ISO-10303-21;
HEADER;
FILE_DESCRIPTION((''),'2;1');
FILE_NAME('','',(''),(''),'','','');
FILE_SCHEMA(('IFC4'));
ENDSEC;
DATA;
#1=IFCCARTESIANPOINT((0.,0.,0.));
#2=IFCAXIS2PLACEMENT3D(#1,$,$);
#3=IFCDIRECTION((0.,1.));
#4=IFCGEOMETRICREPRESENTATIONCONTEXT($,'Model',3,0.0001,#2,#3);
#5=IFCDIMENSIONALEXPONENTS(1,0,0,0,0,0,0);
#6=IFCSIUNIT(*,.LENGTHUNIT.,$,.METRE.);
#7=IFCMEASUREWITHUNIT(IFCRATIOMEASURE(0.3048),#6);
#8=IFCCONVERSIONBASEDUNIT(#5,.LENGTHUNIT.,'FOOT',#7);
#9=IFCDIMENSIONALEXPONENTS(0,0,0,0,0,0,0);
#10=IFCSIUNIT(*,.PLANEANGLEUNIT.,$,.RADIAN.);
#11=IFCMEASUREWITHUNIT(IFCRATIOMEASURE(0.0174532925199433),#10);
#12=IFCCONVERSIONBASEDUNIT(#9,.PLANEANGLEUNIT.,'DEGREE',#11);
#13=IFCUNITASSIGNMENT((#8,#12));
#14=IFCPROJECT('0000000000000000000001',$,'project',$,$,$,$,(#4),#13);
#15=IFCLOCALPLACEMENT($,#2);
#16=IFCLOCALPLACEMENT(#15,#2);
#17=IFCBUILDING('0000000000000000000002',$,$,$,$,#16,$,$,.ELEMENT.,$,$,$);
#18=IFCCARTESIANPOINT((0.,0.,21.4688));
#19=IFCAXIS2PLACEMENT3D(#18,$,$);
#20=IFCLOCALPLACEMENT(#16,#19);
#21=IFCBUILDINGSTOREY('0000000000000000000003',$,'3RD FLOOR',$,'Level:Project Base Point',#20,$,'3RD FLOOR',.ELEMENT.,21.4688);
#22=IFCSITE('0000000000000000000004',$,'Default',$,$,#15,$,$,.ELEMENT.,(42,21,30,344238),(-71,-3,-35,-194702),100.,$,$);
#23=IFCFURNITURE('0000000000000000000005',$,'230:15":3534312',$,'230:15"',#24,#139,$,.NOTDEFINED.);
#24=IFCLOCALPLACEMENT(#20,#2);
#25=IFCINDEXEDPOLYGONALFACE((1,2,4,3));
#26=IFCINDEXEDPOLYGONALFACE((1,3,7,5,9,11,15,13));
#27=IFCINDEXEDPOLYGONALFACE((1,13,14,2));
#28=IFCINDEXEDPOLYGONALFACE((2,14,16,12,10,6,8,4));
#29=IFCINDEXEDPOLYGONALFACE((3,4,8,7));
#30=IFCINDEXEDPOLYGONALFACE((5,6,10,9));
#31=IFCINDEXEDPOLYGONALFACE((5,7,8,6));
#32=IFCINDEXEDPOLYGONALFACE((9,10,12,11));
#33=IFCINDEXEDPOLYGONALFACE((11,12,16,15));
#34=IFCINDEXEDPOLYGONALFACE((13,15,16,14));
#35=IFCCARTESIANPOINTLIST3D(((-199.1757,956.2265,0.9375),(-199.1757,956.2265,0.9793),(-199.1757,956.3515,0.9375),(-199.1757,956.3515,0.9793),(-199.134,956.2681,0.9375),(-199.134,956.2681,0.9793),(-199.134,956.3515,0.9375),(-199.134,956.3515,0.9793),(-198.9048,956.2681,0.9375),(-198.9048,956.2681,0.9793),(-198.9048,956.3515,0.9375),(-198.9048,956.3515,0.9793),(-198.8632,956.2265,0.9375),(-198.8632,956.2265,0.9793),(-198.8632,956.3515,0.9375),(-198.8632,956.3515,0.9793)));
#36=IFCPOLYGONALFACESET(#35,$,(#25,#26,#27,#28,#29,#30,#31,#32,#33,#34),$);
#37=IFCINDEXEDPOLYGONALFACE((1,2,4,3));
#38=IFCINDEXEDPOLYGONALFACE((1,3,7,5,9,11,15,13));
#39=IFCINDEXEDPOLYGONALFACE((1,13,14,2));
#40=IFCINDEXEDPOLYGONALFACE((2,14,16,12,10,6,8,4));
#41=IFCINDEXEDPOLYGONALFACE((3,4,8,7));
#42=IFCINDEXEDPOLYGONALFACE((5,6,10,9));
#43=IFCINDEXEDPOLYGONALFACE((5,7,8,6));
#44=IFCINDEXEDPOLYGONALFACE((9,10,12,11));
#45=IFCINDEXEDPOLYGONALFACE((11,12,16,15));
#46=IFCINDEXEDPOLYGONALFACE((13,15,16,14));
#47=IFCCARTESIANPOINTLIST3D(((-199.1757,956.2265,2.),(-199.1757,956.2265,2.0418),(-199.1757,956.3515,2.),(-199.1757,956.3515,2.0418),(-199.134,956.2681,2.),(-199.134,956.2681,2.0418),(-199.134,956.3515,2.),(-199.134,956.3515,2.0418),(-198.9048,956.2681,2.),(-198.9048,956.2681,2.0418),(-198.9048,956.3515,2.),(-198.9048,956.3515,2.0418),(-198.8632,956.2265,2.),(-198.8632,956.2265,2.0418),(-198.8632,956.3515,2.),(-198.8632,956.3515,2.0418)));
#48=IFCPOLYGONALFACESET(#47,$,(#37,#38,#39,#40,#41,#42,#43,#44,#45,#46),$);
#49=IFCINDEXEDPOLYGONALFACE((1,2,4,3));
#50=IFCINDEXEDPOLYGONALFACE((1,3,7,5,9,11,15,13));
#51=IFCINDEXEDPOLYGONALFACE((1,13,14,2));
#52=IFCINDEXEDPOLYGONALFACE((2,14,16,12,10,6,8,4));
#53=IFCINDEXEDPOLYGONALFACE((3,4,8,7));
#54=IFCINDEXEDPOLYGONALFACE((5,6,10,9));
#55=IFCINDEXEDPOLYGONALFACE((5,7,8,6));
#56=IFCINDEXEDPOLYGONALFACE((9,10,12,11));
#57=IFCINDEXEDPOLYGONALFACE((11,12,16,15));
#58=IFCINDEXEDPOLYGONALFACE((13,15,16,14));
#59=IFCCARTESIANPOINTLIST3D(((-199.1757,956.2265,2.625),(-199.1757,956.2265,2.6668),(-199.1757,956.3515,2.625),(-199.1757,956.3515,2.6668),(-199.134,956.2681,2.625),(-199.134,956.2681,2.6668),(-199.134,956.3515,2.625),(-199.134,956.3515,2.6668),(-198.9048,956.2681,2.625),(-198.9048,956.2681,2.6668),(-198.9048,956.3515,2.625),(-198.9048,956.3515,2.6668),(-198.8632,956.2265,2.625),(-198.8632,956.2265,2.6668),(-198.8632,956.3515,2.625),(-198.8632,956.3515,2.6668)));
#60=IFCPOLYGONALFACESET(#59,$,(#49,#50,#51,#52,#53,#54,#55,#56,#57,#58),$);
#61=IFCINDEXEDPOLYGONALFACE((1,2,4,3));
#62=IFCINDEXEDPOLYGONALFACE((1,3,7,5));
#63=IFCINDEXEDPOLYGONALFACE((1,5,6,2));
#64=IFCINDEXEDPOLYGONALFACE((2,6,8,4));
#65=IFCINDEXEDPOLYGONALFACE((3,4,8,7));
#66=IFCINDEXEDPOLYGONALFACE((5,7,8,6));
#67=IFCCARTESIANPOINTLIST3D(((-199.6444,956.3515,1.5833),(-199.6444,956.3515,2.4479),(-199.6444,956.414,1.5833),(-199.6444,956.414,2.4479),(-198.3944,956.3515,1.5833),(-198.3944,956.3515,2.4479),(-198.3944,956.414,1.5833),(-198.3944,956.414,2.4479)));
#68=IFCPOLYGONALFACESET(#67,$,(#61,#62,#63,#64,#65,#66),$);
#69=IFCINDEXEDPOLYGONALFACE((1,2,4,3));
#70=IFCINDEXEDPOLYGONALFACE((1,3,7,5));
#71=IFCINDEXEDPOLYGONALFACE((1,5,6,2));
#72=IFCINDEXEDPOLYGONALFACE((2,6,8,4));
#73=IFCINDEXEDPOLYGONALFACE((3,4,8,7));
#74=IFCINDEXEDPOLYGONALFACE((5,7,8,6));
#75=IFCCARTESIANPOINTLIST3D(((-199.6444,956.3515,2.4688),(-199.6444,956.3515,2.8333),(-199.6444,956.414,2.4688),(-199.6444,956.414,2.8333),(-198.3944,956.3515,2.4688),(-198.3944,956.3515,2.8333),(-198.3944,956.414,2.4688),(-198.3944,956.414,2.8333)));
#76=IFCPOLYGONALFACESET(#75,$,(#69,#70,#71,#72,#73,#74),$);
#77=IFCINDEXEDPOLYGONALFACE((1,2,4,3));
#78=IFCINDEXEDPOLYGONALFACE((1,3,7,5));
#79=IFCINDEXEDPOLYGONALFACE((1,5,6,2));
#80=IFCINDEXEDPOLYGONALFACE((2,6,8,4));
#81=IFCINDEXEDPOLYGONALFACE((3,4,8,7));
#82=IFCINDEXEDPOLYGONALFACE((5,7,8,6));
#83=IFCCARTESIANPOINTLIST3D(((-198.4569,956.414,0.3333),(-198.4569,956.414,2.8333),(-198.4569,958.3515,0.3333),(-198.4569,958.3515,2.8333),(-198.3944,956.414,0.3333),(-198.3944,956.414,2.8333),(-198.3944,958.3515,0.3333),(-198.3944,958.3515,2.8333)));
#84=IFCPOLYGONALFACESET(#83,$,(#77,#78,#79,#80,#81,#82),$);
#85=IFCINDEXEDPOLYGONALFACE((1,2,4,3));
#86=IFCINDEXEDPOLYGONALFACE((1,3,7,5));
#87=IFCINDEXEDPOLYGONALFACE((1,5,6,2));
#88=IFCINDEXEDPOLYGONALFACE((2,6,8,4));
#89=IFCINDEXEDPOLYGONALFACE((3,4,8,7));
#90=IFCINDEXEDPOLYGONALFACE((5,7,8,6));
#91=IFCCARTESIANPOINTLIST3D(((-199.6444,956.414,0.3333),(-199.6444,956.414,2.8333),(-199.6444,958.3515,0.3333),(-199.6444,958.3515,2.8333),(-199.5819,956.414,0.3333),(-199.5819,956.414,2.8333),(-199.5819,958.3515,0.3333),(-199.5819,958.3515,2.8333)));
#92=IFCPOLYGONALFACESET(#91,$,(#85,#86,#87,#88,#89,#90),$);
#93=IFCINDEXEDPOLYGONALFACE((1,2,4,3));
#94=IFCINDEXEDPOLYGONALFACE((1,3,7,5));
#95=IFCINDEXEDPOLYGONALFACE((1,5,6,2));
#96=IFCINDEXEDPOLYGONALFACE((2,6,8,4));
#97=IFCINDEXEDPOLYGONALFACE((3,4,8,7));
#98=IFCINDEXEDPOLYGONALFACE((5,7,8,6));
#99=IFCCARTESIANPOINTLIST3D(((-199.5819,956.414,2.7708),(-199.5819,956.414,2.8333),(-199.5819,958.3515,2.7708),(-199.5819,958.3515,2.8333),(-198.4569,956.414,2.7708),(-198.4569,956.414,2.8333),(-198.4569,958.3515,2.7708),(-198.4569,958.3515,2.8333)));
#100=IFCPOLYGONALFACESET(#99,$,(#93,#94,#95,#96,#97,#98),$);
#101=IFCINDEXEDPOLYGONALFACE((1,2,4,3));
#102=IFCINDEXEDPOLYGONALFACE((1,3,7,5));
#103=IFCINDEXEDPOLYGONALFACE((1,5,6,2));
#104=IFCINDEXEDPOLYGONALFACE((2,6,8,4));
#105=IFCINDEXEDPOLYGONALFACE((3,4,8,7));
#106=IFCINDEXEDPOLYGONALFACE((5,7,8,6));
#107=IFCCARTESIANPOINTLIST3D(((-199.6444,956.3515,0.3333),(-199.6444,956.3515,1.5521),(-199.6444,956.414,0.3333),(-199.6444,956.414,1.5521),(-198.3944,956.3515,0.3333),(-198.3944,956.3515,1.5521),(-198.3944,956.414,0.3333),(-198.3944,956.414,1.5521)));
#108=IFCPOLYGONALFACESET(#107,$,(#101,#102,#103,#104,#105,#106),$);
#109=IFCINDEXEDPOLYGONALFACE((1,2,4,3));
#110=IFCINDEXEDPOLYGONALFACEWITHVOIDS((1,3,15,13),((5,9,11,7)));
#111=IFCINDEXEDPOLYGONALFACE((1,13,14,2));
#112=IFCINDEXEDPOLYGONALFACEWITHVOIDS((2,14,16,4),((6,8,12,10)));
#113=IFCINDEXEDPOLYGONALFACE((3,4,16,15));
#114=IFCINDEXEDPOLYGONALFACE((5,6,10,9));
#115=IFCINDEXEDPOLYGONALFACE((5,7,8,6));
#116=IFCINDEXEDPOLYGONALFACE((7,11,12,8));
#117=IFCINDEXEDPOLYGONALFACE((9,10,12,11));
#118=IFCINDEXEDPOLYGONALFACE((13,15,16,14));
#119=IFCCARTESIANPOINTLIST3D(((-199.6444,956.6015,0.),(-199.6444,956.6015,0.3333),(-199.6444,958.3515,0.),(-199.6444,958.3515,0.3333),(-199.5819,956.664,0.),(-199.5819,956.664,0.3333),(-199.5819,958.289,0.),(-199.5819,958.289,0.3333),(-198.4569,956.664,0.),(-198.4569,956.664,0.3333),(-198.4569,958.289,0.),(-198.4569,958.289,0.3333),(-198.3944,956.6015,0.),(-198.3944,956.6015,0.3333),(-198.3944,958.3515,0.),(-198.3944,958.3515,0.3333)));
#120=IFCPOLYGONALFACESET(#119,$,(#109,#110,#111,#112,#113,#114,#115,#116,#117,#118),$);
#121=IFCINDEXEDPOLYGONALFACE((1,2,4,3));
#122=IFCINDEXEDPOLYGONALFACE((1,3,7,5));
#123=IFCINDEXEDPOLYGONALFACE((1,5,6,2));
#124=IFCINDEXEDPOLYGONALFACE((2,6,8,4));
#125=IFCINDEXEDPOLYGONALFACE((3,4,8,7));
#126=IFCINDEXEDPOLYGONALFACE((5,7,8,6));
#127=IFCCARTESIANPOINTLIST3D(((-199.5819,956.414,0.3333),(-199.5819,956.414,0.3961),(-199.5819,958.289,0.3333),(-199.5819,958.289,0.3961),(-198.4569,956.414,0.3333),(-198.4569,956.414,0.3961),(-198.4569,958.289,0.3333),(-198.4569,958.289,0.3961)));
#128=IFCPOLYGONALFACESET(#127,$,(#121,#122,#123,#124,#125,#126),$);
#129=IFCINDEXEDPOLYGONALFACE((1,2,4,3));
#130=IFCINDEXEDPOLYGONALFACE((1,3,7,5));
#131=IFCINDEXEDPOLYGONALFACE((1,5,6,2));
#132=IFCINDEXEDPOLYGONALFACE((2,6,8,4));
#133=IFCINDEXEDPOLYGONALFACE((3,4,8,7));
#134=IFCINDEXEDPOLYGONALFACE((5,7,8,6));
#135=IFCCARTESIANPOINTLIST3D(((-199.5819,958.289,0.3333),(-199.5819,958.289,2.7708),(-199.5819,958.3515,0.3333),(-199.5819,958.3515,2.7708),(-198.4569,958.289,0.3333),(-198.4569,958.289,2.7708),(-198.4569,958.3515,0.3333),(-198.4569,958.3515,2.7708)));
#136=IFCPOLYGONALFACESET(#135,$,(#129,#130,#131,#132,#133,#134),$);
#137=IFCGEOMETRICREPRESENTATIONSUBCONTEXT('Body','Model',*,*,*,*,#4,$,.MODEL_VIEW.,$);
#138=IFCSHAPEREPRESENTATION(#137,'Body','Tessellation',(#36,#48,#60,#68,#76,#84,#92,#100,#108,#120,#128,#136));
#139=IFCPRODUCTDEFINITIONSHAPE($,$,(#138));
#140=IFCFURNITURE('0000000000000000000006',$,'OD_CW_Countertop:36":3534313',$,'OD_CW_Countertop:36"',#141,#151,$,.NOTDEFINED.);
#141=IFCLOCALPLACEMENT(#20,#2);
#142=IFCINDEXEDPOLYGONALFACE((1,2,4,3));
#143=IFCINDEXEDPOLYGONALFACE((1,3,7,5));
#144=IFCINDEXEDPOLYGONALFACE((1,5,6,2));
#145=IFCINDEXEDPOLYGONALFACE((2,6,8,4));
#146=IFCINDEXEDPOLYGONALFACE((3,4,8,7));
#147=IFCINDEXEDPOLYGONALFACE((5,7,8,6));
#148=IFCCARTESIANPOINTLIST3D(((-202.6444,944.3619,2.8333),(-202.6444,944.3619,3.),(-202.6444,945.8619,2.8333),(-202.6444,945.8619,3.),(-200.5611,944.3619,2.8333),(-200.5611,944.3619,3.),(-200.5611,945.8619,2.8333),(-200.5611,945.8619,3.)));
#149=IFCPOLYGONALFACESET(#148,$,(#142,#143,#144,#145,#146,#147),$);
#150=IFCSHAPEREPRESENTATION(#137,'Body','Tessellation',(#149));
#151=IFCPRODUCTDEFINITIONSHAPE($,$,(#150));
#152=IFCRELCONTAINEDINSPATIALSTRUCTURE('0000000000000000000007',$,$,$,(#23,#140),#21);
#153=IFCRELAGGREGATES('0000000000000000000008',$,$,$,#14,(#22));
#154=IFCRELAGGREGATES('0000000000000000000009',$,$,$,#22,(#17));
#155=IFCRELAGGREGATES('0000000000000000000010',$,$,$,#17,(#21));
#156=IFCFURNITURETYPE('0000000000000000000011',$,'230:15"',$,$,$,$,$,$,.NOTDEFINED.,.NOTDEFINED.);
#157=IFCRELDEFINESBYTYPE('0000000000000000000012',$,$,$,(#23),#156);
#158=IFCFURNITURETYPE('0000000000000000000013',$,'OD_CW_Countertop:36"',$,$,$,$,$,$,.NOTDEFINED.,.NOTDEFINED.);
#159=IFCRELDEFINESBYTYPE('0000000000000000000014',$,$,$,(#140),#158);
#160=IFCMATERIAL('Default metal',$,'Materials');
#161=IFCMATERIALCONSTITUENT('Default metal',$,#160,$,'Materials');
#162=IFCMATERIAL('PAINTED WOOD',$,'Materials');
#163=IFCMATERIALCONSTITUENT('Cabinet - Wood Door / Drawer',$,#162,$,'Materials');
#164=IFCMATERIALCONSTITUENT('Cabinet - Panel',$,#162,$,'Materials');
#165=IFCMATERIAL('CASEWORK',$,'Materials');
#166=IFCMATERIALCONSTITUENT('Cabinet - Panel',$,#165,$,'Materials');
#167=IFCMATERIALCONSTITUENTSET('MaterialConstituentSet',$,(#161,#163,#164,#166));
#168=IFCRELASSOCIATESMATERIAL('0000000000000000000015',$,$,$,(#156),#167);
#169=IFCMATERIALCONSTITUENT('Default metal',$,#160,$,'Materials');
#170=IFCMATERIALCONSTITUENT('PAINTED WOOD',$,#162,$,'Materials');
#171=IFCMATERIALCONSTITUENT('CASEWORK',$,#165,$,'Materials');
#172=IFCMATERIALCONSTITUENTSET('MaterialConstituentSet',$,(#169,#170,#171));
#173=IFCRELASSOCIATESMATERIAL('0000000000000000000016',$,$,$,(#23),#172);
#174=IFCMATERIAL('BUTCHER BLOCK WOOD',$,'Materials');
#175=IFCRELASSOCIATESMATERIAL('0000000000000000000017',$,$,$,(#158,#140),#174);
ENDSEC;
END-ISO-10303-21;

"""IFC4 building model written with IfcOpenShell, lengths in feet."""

from ifc_helpers import new_model, entity, si_unit, converted_unit, direction, frame, frame_2d, origin, origin_2d_with_axis, place, context, subcontext, project, spatial, polyline, rectangle, outline, extrude, source, transform, mapped, material, constituent, constituent_set, type_object, type_shapes, element, save


model = new_model("IFC4")

# Units and contexts
model_context = context("Model", 3, precision=0.0001, world=origin(), true_north=direction((0.0, 1.0)))
body_context = subcontext(model_context, "Body", "Model", "MODEL_VIEW")
ifc_project = project(units=[converted_unit("LENGTHUNIT", "FOOT", entity("IfcRatioMeasure", 0.3048), si_unit("LENGTHUNIT", "METRE"), dimensions=[1, 0, 0, 0, 0, 0, 0]), converted_unit("PLANEANGLEUNIT", "DEGREE", entity("IfcRatioMeasure", 0.0174532925199433), si_unit("PLANEANGLEUNIT", "RADIAN"), dimensions=[0, 0, 0, 0, 0, 0, 0])], contexts=[model_context])

# Site, building, storey
site_placement = place(None, origin())
site = spatial("IfcSite", under=ifc_project, at=site_placement, Name="Default", CompositionType="ELEMENT", RefLatitude=(42, 21, 30, 344238), RefLongitude=(-71, -3, -35, -194702), RefElevation=100.0)
building_placement = place(site_placement, origin())
building = spatial("IfcBuilding", under=site, at=building_placement, CompositionType="ELEMENT")
storey_placement = place(building_placement, frame((0.0, 0.0, 21.4688)))
storey = spatial("IfcBuildingStorey", under=building, at=storey_placement, Name="3RD FLOOR", ObjectType="Level:Project Base Point", LongName="3RD FLOOR", CompositionType="ELEMENT", Elevation=21.4688)

# Furniture
ifc_material_1 = material(Name="Default metal", Category="Materials")
ifc_material_2 = material(Name="PAINTED WOOD", Category="Materials")
ifc_material_3 = material(Name="CASEWORK", Category="Materials")
ifc_material_4 = material(Name="BUTCHER BLOCK WOOD", Category="Materials")
ifc_constituent_1 = constituent(ifc_material_1, Name="Default metal", Category="Materials")
ifc_constituent_2 = constituent(ifc_material_2, Name="PAINTED WOOD", Category="Materials")
ifc_constituent_3 = constituent(ifc_material_3, Name="CASEWORK", Category="Materials")
ifc_constituent_set_1 = constituent_set(constituents=[ifc_constituent_1, ifc_constituent_2, ifc_constituent_3], Name="MaterialConstituentSet")
ifc_constituent_4 = constituent(ifc_material_1, Name="Default metal", Category="Materials")
ifc_constituent_5 = constituent(ifc_material_2, Name="Cabinet - Wood Door / Drawer", Category="Materials")
ifc_constituent_6 = constituent(ifc_material_2, Name="Cabinet - Panel", Category="Materials")
ifc_constituent_7 = constituent(ifc_material_3, Name="Cabinet - Panel", Category="Materials")
ifc_constituent_set_2 = constituent_set(constituents=[ifc_constituent_4, ifc_constituent_5, ifc_constituent_6, ifc_constituent_7], Name="MaterialConstituentSet")
furniture_type_1 = type_object("IfcFurnitureType", Name="230:15\"", AssemblyPlace="NOTDEFINED", PredefinedType="NOTDEFINED", material=ifc_constituent_set_2)
shared_shape_1 = source(origin(), body_context, "Body", "SweptSolid", [
    extrude(outline(polyline([(-0.1562, -0.0521), (-0.1146, -0.0521), (-0.1146, 0.0313), (0.1146, 0.0313), (0.1146, -0.0521), (0.1562, -0.0521), (0.1562, 0.0729), (-0.1562, 0.0729), (-0.1562, -0.0521)])), frame((0.0615, 2.0521, 0.9375)), (0.0, 0.0, 1.0), 0.0418),
    extrude(outline(polyline([(-0.1562, -0.0521), (-0.1146, -0.0521), (-0.1146, 0.0313), (0.1146, 0.0313), (0.1146, -0.0521), (0.1562, -0.0521), (0.1562, 0.0729), (-0.1562, 0.0729), (-0.1562, -0.0521)])), frame((0.0615, 2.0521, 2.0)), (0.0, 0.0, 1.0), 0.0418),
    extrude(outline(polyline([(-0.1562, -0.0521), (-0.1146, -0.0521), (-0.1146, 0.0313), (0.1146, 0.0313), (0.1146, -0.0521), (0.1562, -0.0521), (0.1562, 0.0729), (-0.1562, 0.0729), (-0.1562, -0.0521)])), frame((0.0615, 2.0521, 2.625)), (0.0, 0.0, 1.0), 0.0418),
    extrude(rectangle(XDim=1.25, YDim=0.0625, at=frame_2d((0.0, 0.0), x_axis=(1.0, 0.0))), frame((0.0615, 1.9688, 1.5833), z_axis=(0.0, 0.0, 1.0), x_axis=(-1.0, 0.0, 0.0)), (0.0, 0.0, 1.0), 0.8646),
    extrude(rectangle(XDim=1.25, YDim=0.0625, at=frame_2d((0.0, 0.0), x_axis=(1.0, 0.0))), frame((0.0615, 1.9688, 2.4688), z_axis=(0.0, 0.0, 1.0), x_axis=(-1.0, 0.0, 0.0)), (0.0, 0.0, 1.0), 0.3646),
    extrude(rectangle(XDim=1.9375, YDim=0.0625, at=frame_2d((0.0, 0.0), x_axis=(1.0, 0.0))), frame((-0.5323, 0.9687, 0.3333), z_axis=(0.0, 0.0, 1.0), x_axis=(0.0, -1.0, 0.0)), (0.0, 0.0, 1.0), 2.5),
    extrude(rectangle(XDim=1.9375, YDim=0.0625, at=frame_2d((0.0, 0.0), x_axis=(1.0, 0.0))), frame((0.6552, 0.9687, 0.3333), z_axis=(0.0, 0.0, 1.0), x_axis=(0.0, -1.0, 0.0)), (0.0, 0.0, 1.0), 2.5),
    extrude(rectangle(XDim=1.9375, YDim=1.125, at=origin_2d_with_axis()), frame((0.0615, 0.9687, 2.7708), z_axis=(0.0, 0.0, 1.0), x_axis=(0.0, 1.0, 0.0)), (0.0, 0.0, 1.0), 0.0625),
    extrude(rectangle(XDim=1.25, YDim=0.0625, at=frame_2d((0.0, 0.0), x_axis=(1.0, 0.0))), frame((0.0615, 1.9688, 0.3333), z_axis=(0.0, 0.0, 1.0), x_axis=(-1.0, 0.0, 0.0)), (0.0, 0.0, 1.0), 1.2187),
    extrude(outline(polyline([(-0.875, -0.625), (0.875, -0.625), (0.875, 0.625), (-0.875, 0.625), (-0.875, -0.625)]), holes=[polyline([(-0.8125, -0.5625), (-0.8125, 0.5625), (0.8125, 0.5625), (0.8125, -0.5625), (-0.8125, -0.5625)])]), frame((0.0615, 0.875, 0.0), z_axis=(0.0, 0.0, 1.0), x_axis=(0.0, -1.0, 0.0)), (0.0, 0.0, 1.0), 0.3333),
    extrude(rectangle(XDim=1.875, YDim=1.125, at=origin_2d_with_axis()), frame((0.0615, 1.0, 0.3333), z_axis=(0.0, 0.0, 1.0), x_axis=(0.0, 1.0, 0.0)), (0.0, 0.0, 1.0), 0.0627),
    extrude(rectangle(XDim=1.125, YDim=0.0625, at=origin_2d_with_axis()), frame((0.0615, 0.0312, 0.3333), z_axis=(0.0, 0.0, 1.0), x_axis=(-1.0, 0.0, 0.0)), (0.0, 0.0, 1.0), 2.4375),
])
type_shapes(furniture_type_1, [shared_shape_1])
furniture_1_placement = place(storey_placement, frame((-198.9579, 958.3515, 0.0), z_axis=(0.0, 0.0, 1.0), x_axis=(-1.0, 0.0, 0.0)))
element("IfcFurniture", 1, at=furniture_1_placement, inside=storey, type_object=furniture_type_1, material=ifc_constituent_set_1, Name="230:15\":3534312", ObjectType="230:15\"", PredefinedType="NOTDEFINED", context=body_context, shape_type="MappedRepresentation", body=[
    mapped(shared_shape_1, transform((0.0, 0.0, 0.0), scale=1.0)),
])
furniture_type_2 = type_object("IfcFurnitureType", Name="OD_CW_Countertop:36\"", AssemblyPlace="NOTDEFINED", PredefinedType="NOTDEFINED", material=ifc_material_4)
shared_shape_2 = source(origin(), body_context, "Body", "SweptSolid", [
    extrude(rectangle(XDim=2.0833, YDim=1.5, at=origin_2d_with_axis()), frame((0.75, 1.0417, 0.0), z_axis=(0.0, 0.0, 1.0), x_axis=(0.0, -1.0, 0.0)), (0.0, 0.0, 1.0), 0.1667),
])
type_shapes(furniture_type_2, [shared_shape_2])
furniture_2_placement = place(storey_placement, frame((-200.5611, 944.3619, 2.8333), z_axis=(0.0, 0.0, 1.0), x_axis=(0.0, 1.0, 0.0)))
element("IfcFurniture", 2, at=furniture_2_placement, inside=storey, type_object=furniture_type_2, material=ifc_material_4, Name="OD_CW_Countertop:36\":3534313", ObjectType="OD_CW_Countertop:36\"", PredefinedType="NOTDEFINED", context=body_context, shape_type="MappedRepresentation", body=[
    mapped(shared_shape_2, transform((0.0, 0.0, 0.0), scale=1.0)),
])

save(model, "model.ifc")
